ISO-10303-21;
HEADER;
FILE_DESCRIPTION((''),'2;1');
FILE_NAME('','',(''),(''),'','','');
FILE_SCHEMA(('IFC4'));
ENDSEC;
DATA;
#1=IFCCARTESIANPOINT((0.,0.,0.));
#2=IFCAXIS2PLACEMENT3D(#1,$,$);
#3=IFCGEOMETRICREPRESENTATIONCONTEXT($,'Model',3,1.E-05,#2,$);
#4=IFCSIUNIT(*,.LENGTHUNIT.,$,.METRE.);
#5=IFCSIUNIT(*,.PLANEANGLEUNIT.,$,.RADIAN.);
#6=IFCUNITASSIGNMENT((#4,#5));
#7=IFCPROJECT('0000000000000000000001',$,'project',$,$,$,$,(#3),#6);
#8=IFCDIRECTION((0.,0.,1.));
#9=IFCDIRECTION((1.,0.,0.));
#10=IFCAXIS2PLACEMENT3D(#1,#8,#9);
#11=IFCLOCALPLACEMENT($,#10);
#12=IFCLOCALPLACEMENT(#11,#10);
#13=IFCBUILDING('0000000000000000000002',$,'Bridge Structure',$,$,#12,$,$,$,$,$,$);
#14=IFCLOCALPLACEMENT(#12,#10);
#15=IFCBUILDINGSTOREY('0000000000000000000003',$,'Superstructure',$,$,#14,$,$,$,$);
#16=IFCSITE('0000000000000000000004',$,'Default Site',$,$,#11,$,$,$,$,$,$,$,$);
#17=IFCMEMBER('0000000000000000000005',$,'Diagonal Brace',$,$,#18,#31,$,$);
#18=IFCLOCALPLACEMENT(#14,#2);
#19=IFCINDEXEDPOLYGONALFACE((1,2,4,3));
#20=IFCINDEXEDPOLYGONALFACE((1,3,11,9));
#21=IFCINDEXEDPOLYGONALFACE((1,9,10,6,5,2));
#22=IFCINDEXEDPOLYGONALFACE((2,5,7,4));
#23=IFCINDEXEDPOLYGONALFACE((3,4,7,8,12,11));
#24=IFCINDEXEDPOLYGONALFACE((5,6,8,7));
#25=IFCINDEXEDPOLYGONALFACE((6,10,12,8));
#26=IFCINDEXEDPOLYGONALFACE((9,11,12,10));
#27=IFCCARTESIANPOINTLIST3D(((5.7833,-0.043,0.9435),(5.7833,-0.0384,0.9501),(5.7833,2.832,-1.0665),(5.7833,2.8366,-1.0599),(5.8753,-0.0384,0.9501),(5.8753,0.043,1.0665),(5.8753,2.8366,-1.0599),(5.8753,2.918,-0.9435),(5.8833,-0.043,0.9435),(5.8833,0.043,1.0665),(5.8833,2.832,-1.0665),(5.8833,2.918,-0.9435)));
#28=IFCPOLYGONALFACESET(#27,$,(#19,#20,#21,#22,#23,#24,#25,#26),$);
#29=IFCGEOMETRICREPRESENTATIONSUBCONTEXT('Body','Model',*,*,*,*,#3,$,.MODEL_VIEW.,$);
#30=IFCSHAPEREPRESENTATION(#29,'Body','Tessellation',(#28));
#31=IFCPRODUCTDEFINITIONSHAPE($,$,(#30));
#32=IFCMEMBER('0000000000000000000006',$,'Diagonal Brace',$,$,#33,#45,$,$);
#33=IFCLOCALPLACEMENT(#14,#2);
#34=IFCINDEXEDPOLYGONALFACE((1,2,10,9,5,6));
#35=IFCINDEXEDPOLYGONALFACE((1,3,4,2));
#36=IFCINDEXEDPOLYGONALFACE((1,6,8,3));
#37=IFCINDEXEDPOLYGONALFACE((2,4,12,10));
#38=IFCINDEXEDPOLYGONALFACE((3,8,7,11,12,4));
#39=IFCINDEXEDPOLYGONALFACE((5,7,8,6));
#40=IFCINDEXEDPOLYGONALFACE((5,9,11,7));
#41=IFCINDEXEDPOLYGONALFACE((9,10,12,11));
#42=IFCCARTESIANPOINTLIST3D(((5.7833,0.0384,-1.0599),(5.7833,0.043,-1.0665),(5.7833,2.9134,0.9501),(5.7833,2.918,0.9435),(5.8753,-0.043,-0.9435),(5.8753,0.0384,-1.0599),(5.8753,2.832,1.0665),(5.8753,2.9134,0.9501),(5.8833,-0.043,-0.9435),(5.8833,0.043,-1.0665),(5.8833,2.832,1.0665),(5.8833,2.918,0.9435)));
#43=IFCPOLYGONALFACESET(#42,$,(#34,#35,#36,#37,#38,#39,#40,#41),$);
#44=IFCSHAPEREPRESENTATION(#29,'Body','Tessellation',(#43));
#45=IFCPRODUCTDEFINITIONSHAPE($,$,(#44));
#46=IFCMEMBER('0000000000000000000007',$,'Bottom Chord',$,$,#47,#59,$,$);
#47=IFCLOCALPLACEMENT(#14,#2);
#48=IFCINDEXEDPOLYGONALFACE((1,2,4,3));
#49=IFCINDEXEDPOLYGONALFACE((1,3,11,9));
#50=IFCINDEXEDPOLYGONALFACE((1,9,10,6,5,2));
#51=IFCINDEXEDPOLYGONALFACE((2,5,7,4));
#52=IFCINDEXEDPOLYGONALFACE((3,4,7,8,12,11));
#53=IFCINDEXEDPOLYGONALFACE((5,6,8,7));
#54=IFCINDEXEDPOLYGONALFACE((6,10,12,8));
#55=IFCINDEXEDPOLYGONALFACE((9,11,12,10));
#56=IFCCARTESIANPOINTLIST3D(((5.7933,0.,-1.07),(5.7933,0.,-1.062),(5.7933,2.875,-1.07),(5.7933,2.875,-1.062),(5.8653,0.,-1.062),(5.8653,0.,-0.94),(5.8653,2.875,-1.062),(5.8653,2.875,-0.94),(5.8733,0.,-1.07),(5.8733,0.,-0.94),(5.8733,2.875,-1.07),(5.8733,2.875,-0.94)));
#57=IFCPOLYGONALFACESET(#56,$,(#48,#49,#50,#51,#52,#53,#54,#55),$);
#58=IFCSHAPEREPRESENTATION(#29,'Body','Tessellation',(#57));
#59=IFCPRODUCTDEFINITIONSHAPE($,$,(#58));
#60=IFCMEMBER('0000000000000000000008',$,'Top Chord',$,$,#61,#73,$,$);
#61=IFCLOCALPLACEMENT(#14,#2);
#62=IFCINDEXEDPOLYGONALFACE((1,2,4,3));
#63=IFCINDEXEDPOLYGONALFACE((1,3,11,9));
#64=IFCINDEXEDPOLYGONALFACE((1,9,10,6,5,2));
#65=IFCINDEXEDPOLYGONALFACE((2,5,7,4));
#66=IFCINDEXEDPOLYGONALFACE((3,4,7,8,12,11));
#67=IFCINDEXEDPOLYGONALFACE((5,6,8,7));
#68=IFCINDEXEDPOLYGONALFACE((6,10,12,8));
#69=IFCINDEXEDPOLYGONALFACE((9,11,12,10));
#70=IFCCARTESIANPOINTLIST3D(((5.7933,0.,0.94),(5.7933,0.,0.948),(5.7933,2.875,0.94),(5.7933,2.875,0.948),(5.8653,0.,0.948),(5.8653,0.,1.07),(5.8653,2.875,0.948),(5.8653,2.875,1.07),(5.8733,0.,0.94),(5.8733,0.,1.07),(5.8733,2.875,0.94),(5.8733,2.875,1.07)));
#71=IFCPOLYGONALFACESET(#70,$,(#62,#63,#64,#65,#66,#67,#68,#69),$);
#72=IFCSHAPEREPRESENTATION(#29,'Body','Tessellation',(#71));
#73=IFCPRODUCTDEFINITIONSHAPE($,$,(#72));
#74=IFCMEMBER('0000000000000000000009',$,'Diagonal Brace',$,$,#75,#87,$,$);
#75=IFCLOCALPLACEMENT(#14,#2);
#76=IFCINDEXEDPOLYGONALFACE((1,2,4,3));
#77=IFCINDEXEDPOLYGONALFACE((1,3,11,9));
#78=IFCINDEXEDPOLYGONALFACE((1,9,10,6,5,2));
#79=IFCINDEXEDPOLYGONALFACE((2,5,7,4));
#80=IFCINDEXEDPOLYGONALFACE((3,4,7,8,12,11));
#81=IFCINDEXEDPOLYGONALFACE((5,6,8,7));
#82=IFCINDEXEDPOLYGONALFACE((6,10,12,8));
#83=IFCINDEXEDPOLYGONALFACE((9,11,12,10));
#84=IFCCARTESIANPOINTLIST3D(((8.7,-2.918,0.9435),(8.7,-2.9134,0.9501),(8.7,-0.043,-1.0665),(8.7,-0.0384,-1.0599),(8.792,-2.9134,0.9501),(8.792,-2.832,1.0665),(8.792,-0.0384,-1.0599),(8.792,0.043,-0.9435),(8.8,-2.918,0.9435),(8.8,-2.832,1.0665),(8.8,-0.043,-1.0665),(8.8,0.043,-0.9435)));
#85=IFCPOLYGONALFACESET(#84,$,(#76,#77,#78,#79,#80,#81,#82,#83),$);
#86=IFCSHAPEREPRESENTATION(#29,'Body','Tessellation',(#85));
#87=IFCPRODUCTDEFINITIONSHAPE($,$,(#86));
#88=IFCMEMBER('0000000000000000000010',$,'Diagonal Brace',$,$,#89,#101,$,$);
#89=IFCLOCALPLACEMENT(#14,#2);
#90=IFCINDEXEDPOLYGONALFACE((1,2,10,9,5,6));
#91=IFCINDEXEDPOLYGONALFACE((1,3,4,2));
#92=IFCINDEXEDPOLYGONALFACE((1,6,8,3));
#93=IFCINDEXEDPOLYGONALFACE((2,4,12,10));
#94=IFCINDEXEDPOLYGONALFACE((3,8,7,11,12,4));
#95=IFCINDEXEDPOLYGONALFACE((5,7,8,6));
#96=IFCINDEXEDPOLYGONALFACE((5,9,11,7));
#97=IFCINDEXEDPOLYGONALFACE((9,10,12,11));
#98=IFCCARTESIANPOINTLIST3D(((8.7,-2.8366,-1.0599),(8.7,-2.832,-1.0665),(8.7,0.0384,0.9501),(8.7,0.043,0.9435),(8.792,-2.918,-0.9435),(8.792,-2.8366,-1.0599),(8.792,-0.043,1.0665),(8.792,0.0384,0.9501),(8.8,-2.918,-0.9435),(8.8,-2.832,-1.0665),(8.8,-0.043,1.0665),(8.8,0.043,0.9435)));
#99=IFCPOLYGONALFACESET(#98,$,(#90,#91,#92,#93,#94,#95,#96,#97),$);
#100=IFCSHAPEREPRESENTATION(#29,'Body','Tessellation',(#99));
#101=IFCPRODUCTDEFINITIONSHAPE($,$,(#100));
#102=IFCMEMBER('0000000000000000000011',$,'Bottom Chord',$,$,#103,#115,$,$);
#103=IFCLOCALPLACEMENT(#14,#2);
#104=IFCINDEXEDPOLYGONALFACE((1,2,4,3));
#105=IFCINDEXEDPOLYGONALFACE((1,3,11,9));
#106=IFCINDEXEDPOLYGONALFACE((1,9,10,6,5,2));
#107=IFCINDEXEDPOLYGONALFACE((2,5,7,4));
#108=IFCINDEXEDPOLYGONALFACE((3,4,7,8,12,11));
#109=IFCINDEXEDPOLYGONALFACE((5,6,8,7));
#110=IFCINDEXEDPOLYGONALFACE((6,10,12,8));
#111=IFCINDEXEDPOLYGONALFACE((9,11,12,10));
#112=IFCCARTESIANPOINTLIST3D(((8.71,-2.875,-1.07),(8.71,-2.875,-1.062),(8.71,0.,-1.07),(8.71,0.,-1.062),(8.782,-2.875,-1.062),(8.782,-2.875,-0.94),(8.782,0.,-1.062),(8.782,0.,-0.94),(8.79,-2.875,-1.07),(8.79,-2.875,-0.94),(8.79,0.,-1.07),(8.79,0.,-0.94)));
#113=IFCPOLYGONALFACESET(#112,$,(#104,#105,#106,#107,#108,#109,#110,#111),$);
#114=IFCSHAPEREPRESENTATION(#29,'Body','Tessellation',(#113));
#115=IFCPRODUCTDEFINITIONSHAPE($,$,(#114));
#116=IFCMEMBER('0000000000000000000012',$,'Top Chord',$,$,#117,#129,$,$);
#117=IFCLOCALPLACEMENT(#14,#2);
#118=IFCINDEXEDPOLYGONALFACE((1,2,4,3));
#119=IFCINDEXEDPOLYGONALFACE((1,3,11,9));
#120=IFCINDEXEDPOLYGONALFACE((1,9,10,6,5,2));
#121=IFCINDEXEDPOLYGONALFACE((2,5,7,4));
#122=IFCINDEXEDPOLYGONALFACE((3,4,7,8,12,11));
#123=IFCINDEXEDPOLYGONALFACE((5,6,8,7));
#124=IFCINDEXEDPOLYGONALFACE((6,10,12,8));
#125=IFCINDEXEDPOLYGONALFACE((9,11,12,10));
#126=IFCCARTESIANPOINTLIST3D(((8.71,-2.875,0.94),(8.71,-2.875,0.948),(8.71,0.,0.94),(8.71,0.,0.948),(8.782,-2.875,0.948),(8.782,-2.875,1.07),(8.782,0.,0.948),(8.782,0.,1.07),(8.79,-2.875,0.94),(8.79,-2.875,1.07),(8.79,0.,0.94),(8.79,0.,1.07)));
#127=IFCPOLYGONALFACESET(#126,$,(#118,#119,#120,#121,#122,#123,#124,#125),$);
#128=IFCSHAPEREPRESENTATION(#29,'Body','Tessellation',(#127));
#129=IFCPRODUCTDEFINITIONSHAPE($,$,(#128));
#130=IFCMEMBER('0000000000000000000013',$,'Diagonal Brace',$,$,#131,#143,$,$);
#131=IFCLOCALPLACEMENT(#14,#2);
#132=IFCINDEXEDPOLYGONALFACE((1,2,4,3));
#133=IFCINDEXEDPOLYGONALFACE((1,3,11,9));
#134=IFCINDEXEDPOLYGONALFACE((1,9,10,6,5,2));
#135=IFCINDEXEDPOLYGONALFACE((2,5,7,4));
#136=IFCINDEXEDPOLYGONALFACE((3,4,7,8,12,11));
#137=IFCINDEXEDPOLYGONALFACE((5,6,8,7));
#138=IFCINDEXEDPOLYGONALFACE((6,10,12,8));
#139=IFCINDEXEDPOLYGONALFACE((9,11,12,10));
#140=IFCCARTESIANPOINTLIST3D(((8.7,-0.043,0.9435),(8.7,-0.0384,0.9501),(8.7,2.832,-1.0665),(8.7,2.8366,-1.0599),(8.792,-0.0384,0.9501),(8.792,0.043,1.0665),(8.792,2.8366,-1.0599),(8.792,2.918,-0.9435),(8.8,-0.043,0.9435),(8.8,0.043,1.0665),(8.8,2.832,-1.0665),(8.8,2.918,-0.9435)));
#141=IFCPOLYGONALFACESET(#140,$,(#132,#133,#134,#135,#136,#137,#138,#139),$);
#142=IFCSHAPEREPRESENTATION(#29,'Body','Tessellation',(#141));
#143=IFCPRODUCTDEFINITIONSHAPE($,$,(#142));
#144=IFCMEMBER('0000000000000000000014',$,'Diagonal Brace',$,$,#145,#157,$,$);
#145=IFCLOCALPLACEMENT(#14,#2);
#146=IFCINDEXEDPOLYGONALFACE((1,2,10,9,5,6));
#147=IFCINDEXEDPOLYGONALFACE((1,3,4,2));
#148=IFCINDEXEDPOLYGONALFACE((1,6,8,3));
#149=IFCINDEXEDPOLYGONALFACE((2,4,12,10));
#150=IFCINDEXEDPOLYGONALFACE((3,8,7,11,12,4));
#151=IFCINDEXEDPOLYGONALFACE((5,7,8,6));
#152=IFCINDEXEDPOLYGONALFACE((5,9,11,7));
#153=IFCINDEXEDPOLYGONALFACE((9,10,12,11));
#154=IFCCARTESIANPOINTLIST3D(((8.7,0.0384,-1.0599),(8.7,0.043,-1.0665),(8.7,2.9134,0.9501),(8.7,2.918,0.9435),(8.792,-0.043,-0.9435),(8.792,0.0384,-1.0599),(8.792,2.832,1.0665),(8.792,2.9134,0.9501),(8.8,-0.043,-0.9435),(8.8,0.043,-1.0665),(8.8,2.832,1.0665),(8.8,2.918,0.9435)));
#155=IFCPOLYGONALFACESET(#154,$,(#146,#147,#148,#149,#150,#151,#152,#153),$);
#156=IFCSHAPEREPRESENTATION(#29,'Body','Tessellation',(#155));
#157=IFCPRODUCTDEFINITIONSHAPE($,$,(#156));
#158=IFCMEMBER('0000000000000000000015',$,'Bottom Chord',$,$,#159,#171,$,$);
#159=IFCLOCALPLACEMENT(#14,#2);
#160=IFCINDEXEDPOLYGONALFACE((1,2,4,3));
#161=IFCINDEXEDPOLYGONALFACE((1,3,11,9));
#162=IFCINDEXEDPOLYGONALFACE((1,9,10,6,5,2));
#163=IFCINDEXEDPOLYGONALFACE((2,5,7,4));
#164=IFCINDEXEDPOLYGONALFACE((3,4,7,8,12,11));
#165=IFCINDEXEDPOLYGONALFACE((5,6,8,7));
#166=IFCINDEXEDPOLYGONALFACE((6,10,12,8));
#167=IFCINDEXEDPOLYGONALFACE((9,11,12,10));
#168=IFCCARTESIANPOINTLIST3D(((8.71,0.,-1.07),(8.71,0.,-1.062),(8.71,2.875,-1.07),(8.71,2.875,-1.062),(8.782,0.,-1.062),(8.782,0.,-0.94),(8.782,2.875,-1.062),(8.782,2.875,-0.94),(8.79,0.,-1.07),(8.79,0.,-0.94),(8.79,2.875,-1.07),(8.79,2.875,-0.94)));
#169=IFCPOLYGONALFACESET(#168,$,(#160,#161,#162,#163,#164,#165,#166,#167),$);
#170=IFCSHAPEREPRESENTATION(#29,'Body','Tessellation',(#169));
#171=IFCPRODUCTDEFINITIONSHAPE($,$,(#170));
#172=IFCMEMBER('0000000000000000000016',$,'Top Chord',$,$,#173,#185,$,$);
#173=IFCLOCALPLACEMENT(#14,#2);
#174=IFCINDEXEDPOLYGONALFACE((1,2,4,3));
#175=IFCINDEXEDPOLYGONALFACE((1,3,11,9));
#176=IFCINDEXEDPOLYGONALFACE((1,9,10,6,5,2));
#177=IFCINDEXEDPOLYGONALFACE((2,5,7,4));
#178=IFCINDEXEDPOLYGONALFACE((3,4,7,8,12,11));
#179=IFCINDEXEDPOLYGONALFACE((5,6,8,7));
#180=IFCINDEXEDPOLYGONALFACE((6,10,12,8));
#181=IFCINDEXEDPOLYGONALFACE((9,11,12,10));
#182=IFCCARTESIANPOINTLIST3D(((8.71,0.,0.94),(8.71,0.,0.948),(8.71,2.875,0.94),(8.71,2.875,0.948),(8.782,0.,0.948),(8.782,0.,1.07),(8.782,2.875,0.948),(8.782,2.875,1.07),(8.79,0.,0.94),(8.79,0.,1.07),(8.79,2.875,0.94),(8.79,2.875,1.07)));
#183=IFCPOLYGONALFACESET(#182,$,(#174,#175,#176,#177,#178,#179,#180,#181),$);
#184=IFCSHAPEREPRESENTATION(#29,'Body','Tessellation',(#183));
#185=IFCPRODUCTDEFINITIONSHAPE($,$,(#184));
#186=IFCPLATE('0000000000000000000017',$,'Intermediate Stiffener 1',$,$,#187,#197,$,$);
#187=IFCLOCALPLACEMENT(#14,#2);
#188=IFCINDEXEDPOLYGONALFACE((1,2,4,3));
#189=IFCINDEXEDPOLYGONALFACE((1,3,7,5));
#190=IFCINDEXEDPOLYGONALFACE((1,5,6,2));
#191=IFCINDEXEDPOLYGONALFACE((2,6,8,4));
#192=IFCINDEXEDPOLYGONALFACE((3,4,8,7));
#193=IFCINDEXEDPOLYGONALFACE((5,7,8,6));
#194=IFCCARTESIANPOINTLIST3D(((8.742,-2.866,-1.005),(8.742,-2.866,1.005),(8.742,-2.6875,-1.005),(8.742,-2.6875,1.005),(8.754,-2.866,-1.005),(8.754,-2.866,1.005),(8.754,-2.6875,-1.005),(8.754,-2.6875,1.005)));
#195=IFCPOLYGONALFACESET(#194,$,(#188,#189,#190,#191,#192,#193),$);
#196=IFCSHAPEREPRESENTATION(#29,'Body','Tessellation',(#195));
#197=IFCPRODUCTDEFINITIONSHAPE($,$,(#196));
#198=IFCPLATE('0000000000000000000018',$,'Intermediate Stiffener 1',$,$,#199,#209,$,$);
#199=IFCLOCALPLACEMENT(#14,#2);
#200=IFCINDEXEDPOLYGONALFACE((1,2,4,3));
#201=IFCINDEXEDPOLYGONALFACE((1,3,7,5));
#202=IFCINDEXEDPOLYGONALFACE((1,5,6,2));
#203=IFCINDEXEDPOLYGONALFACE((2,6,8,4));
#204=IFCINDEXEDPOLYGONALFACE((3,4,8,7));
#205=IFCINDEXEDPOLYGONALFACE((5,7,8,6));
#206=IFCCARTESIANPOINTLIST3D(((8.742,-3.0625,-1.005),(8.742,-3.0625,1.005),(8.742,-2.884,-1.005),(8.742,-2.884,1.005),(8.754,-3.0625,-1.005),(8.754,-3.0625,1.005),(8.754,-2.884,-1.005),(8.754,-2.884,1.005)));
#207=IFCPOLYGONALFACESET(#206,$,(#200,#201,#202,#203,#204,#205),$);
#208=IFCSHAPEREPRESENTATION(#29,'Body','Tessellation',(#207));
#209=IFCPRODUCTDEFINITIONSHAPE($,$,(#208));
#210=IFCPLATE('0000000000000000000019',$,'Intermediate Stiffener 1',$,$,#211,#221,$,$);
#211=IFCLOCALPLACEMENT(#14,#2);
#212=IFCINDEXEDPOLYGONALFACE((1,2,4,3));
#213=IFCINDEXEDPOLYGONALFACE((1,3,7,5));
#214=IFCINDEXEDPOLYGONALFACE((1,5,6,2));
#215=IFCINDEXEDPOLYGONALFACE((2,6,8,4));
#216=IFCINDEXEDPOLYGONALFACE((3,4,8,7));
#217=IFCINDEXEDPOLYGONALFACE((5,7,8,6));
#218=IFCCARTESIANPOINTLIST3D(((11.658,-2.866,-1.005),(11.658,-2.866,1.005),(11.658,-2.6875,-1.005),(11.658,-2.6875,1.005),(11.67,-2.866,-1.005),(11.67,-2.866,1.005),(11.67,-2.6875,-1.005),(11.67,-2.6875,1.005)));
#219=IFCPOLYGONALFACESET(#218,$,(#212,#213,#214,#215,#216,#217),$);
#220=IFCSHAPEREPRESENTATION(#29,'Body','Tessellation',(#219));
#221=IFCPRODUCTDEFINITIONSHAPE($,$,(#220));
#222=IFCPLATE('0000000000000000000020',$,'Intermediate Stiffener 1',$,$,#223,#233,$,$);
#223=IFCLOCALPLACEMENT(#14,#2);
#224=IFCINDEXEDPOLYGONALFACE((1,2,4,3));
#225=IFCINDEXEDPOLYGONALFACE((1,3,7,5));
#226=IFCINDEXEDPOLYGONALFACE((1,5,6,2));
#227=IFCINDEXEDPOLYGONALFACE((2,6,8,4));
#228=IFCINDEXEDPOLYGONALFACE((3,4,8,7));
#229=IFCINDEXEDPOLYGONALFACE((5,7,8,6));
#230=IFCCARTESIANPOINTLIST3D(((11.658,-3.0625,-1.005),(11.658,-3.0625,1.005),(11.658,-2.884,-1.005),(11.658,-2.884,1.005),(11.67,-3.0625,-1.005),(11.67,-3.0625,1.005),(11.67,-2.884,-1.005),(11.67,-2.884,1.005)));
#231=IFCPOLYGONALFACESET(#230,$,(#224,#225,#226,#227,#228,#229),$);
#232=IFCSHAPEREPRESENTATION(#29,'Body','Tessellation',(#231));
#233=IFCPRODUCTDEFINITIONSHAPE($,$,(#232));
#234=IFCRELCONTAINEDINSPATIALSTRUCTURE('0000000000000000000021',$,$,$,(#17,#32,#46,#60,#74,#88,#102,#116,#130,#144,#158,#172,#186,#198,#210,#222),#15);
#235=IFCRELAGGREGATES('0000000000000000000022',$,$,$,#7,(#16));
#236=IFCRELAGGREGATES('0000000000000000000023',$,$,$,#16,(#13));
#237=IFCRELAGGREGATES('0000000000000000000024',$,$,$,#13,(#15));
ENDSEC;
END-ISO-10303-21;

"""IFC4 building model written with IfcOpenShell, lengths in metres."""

from ifc_helpers import new_model, si_unit, frame, origin, origin_with_axes, origin_2d_with_axis, place, context, subcontext, project, spatial, rectangle, l_section, extrude, element, save


model = new_model("IFC4")

# Units and contexts
model_context = context("Model", 3, precision=1e-05, world=origin())
body_context = subcontext(model_context, "Body", "Model", "MODEL_VIEW")
ifc_project = project(units=[si_unit("LENGTHUNIT", "METRE"), si_unit("PLANEANGLEUNIT", "RADIAN")], contexts=[model_context])

# Site, building, storey
site_placement = place(None, origin_with_axes())
site = spatial("IfcSite", under=ifc_project, at=site_placement, Name="Default Site")
building_placement = place(site_placement, origin_with_axes())
building = spatial("IfcBuilding", under=site, at=building_placement, Name="Bridge Structure")
storey_placement = place(building_placement, origin_with_axes())
storey = spatial("IfcBuildingStorey", under=building, at=storey_placement, Name="Superstructure")

# Members
for number, where, z_axis, x_axis, name in (
    (1, (5.8333, 0.0, 1.005), (0.0, 0.819567, -0.572984), (-1.0, 0.0, 0.0), "Diagonal Brace"),
    (2, (5.8333, 0.0, -1.005), (0.0, 0.819567, 0.572984), (-1.0, 0.0, 0.0), "Diagonal Brace"),
):
    element("IfcMember", number, at=place(storey_placement, frame(where, z_axis=z_axis, x_axis=x_axis)), inside=storey, Name=name, context=body_context, shape_type="SweptSolid", body=[
        extrude(l_section(Depth=0.15, Width=0.1, Thickness=0.008, at=origin_2d_with_axis()), origin_with_axes(), (0.0, 0.0, 1.0), 3.508),
    ])
for number, where, z_axis, x_axis, name in (
    (3, (5.8333, 0.0, -1.005), (0.0, 1.0, 0.0), (-1.0, 0.0, 0.0), "Bottom Chord"),
    (4, (5.8333, 0.0, 1.005), (0.0, 1.0, 0.0), (-1.0, 0.0, 0.0), "Top Chord"),
):
    element("IfcMember", number, at=place(storey_placement, frame(where, z_axis=z_axis, x_axis=x_axis)), inside=storey, Name=name, context=body_context, shape_type="SweptSolid", body=[
        extrude(l_section(Depth=0.13, Width=0.08, Thickness=0.008, at=origin_2d_with_axis()), origin_with_axes(), (0.0, 0.0, 1.0), 2.875),
    ])
for number, where, z_axis, x_axis, name in (
    (5, (8.75, -2.875, 1.005), (0.0, 0.819567, -0.572984), (-1.0, 0.0, 0.0), "Diagonal Brace"),
    (6, (8.75, -2.875, -1.005), (0.0, 0.819567, 0.572984), (-1.0, 0.0, 0.0), "Diagonal Brace"),
):
    element("IfcMember", number, at=place(storey_placement, frame(where, z_axis=z_axis, x_axis=x_axis)), inside=storey, Name=name, context=body_context, shape_type="SweptSolid", body=[
        extrude(l_section(Depth=0.15, Width=0.1, Thickness=0.008, at=origin_2d_with_axis()), origin_with_axes(), (0.0, 0.0, 1.0), 3.508),
    ])
for number, where, z_axis, x_axis, name in (
    (7, (8.75, -2.875, -1.005), (0.0, 1.0, 0.0), (-1.0, 0.0, 0.0), "Bottom Chord"),
    (8, (8.75, -2.875, 1.005), (0.0, 1.0, 0.0), (-1.0, 0.0, 0.0), "Top Chord"),
):
    element("IfcMember", number, at=place(storey_placement, frame(where, z_axis=z_axis, x_axis=x_axis)), inside=storey, Name=name, context=body_context, shape_type="SweptSolid", body=[
        extrude(l_section(Depth=0.13, Width=0.08, Thickness=0.008, at=origin_2d_with_axis()), origin_with_axes(), (0.0, 0.0, 1.0), 2.875),
    ])
for number, where, z_axis, x_axis, name in (
    (9, (8.75, 0.0, 1.005), (0.0, 0.819567, -0.572984), (-1.0, 0.0, 0.0), "Diagonal Brace"),
    (10, (8.75, 0.0, -1.005), (0.0, 0.819567, 0.572984), (-1.0, 0.0, 0.0), "Diagonal Brace"),
):
    element("IfcMember", number, at=place(storey_placement, frame(where, z_axis=z_axis, x_axis=x_axis)), inside=storey, Name=name, context=body_context, shape_type="SweptSolid", body=[
        extrude(l_section(Depth=0.15, Width=0.1, Thickness=0.008, at=origin_2d_with_axis()), origin_with_axes(), (0.0, 0.0, 1.0), 3.508),
    ])
for number, where, z_axis, x_axis, name in (
    (11, (8.75, 0.0, -1.005), (0.0, 1.0, 0.0), (-1.0, 0.0, 0.0), "Bottom Chord"),
    (12, (8.75, 0.0, 1.005), (0.0, 1.0, 0.0), (-1.0, 0.0, 0.0), "Top Chord"),
):
    element("IfcMember", number, at=place(storey_placement, frame(where, z_axis=z_axis, x_axis=x_axis)), inside=storey, Name=name, context=body_context, shape_type="SweptSolid", body=[
        extrude(l_section(Depth=0.13, Width=0.08, Thickness=0.008, at=origin_2d_with_axis()), origin_with_axes(), (0.0, 0.0, 1.0), 2.875),
    ])

# Plates
for number, where, z_axis, x_axis, name in (
    (13, (8.748, -2.7768, -1.005), (0.0, 0.0, 1.0), (1.0, 0.0, 0.0), "Intermediate Stiffener 1"),
    (14, (8.748, -2.9733, -1.005), (0.0, 0.0, 1.0), (1.0, 0.0, 0.0), "Intermediate Stiffener 1"),
    (15, (11.664, -2.7768, -1.005), (0.0, 0.0, 1.0), (1.0, 0.0, 0.0), "Intermediate Stiffener 1"),
    (16, (11.664, -2.9733, -1.005), (0.0, 0.0, 1.0), (1.0, 0.0, 0.0), "Intermediate Stiffener 1"),
):
    element("IfcPlate", number, at=place(storey_placement, frame(where, z_axis=z_axis, x_axis=x_axis)), inside=storey, Name=name, context=body_context, shape_type="SweptSolid", body=[
        extrude(rectangle(XDim=0.012, YDim=0.1785, at=origin_2d_with_axis()), origin_with_axes(), (0.0, 0.0, 1.0), 2.01),
    ])

save(model, "model.ifc")
